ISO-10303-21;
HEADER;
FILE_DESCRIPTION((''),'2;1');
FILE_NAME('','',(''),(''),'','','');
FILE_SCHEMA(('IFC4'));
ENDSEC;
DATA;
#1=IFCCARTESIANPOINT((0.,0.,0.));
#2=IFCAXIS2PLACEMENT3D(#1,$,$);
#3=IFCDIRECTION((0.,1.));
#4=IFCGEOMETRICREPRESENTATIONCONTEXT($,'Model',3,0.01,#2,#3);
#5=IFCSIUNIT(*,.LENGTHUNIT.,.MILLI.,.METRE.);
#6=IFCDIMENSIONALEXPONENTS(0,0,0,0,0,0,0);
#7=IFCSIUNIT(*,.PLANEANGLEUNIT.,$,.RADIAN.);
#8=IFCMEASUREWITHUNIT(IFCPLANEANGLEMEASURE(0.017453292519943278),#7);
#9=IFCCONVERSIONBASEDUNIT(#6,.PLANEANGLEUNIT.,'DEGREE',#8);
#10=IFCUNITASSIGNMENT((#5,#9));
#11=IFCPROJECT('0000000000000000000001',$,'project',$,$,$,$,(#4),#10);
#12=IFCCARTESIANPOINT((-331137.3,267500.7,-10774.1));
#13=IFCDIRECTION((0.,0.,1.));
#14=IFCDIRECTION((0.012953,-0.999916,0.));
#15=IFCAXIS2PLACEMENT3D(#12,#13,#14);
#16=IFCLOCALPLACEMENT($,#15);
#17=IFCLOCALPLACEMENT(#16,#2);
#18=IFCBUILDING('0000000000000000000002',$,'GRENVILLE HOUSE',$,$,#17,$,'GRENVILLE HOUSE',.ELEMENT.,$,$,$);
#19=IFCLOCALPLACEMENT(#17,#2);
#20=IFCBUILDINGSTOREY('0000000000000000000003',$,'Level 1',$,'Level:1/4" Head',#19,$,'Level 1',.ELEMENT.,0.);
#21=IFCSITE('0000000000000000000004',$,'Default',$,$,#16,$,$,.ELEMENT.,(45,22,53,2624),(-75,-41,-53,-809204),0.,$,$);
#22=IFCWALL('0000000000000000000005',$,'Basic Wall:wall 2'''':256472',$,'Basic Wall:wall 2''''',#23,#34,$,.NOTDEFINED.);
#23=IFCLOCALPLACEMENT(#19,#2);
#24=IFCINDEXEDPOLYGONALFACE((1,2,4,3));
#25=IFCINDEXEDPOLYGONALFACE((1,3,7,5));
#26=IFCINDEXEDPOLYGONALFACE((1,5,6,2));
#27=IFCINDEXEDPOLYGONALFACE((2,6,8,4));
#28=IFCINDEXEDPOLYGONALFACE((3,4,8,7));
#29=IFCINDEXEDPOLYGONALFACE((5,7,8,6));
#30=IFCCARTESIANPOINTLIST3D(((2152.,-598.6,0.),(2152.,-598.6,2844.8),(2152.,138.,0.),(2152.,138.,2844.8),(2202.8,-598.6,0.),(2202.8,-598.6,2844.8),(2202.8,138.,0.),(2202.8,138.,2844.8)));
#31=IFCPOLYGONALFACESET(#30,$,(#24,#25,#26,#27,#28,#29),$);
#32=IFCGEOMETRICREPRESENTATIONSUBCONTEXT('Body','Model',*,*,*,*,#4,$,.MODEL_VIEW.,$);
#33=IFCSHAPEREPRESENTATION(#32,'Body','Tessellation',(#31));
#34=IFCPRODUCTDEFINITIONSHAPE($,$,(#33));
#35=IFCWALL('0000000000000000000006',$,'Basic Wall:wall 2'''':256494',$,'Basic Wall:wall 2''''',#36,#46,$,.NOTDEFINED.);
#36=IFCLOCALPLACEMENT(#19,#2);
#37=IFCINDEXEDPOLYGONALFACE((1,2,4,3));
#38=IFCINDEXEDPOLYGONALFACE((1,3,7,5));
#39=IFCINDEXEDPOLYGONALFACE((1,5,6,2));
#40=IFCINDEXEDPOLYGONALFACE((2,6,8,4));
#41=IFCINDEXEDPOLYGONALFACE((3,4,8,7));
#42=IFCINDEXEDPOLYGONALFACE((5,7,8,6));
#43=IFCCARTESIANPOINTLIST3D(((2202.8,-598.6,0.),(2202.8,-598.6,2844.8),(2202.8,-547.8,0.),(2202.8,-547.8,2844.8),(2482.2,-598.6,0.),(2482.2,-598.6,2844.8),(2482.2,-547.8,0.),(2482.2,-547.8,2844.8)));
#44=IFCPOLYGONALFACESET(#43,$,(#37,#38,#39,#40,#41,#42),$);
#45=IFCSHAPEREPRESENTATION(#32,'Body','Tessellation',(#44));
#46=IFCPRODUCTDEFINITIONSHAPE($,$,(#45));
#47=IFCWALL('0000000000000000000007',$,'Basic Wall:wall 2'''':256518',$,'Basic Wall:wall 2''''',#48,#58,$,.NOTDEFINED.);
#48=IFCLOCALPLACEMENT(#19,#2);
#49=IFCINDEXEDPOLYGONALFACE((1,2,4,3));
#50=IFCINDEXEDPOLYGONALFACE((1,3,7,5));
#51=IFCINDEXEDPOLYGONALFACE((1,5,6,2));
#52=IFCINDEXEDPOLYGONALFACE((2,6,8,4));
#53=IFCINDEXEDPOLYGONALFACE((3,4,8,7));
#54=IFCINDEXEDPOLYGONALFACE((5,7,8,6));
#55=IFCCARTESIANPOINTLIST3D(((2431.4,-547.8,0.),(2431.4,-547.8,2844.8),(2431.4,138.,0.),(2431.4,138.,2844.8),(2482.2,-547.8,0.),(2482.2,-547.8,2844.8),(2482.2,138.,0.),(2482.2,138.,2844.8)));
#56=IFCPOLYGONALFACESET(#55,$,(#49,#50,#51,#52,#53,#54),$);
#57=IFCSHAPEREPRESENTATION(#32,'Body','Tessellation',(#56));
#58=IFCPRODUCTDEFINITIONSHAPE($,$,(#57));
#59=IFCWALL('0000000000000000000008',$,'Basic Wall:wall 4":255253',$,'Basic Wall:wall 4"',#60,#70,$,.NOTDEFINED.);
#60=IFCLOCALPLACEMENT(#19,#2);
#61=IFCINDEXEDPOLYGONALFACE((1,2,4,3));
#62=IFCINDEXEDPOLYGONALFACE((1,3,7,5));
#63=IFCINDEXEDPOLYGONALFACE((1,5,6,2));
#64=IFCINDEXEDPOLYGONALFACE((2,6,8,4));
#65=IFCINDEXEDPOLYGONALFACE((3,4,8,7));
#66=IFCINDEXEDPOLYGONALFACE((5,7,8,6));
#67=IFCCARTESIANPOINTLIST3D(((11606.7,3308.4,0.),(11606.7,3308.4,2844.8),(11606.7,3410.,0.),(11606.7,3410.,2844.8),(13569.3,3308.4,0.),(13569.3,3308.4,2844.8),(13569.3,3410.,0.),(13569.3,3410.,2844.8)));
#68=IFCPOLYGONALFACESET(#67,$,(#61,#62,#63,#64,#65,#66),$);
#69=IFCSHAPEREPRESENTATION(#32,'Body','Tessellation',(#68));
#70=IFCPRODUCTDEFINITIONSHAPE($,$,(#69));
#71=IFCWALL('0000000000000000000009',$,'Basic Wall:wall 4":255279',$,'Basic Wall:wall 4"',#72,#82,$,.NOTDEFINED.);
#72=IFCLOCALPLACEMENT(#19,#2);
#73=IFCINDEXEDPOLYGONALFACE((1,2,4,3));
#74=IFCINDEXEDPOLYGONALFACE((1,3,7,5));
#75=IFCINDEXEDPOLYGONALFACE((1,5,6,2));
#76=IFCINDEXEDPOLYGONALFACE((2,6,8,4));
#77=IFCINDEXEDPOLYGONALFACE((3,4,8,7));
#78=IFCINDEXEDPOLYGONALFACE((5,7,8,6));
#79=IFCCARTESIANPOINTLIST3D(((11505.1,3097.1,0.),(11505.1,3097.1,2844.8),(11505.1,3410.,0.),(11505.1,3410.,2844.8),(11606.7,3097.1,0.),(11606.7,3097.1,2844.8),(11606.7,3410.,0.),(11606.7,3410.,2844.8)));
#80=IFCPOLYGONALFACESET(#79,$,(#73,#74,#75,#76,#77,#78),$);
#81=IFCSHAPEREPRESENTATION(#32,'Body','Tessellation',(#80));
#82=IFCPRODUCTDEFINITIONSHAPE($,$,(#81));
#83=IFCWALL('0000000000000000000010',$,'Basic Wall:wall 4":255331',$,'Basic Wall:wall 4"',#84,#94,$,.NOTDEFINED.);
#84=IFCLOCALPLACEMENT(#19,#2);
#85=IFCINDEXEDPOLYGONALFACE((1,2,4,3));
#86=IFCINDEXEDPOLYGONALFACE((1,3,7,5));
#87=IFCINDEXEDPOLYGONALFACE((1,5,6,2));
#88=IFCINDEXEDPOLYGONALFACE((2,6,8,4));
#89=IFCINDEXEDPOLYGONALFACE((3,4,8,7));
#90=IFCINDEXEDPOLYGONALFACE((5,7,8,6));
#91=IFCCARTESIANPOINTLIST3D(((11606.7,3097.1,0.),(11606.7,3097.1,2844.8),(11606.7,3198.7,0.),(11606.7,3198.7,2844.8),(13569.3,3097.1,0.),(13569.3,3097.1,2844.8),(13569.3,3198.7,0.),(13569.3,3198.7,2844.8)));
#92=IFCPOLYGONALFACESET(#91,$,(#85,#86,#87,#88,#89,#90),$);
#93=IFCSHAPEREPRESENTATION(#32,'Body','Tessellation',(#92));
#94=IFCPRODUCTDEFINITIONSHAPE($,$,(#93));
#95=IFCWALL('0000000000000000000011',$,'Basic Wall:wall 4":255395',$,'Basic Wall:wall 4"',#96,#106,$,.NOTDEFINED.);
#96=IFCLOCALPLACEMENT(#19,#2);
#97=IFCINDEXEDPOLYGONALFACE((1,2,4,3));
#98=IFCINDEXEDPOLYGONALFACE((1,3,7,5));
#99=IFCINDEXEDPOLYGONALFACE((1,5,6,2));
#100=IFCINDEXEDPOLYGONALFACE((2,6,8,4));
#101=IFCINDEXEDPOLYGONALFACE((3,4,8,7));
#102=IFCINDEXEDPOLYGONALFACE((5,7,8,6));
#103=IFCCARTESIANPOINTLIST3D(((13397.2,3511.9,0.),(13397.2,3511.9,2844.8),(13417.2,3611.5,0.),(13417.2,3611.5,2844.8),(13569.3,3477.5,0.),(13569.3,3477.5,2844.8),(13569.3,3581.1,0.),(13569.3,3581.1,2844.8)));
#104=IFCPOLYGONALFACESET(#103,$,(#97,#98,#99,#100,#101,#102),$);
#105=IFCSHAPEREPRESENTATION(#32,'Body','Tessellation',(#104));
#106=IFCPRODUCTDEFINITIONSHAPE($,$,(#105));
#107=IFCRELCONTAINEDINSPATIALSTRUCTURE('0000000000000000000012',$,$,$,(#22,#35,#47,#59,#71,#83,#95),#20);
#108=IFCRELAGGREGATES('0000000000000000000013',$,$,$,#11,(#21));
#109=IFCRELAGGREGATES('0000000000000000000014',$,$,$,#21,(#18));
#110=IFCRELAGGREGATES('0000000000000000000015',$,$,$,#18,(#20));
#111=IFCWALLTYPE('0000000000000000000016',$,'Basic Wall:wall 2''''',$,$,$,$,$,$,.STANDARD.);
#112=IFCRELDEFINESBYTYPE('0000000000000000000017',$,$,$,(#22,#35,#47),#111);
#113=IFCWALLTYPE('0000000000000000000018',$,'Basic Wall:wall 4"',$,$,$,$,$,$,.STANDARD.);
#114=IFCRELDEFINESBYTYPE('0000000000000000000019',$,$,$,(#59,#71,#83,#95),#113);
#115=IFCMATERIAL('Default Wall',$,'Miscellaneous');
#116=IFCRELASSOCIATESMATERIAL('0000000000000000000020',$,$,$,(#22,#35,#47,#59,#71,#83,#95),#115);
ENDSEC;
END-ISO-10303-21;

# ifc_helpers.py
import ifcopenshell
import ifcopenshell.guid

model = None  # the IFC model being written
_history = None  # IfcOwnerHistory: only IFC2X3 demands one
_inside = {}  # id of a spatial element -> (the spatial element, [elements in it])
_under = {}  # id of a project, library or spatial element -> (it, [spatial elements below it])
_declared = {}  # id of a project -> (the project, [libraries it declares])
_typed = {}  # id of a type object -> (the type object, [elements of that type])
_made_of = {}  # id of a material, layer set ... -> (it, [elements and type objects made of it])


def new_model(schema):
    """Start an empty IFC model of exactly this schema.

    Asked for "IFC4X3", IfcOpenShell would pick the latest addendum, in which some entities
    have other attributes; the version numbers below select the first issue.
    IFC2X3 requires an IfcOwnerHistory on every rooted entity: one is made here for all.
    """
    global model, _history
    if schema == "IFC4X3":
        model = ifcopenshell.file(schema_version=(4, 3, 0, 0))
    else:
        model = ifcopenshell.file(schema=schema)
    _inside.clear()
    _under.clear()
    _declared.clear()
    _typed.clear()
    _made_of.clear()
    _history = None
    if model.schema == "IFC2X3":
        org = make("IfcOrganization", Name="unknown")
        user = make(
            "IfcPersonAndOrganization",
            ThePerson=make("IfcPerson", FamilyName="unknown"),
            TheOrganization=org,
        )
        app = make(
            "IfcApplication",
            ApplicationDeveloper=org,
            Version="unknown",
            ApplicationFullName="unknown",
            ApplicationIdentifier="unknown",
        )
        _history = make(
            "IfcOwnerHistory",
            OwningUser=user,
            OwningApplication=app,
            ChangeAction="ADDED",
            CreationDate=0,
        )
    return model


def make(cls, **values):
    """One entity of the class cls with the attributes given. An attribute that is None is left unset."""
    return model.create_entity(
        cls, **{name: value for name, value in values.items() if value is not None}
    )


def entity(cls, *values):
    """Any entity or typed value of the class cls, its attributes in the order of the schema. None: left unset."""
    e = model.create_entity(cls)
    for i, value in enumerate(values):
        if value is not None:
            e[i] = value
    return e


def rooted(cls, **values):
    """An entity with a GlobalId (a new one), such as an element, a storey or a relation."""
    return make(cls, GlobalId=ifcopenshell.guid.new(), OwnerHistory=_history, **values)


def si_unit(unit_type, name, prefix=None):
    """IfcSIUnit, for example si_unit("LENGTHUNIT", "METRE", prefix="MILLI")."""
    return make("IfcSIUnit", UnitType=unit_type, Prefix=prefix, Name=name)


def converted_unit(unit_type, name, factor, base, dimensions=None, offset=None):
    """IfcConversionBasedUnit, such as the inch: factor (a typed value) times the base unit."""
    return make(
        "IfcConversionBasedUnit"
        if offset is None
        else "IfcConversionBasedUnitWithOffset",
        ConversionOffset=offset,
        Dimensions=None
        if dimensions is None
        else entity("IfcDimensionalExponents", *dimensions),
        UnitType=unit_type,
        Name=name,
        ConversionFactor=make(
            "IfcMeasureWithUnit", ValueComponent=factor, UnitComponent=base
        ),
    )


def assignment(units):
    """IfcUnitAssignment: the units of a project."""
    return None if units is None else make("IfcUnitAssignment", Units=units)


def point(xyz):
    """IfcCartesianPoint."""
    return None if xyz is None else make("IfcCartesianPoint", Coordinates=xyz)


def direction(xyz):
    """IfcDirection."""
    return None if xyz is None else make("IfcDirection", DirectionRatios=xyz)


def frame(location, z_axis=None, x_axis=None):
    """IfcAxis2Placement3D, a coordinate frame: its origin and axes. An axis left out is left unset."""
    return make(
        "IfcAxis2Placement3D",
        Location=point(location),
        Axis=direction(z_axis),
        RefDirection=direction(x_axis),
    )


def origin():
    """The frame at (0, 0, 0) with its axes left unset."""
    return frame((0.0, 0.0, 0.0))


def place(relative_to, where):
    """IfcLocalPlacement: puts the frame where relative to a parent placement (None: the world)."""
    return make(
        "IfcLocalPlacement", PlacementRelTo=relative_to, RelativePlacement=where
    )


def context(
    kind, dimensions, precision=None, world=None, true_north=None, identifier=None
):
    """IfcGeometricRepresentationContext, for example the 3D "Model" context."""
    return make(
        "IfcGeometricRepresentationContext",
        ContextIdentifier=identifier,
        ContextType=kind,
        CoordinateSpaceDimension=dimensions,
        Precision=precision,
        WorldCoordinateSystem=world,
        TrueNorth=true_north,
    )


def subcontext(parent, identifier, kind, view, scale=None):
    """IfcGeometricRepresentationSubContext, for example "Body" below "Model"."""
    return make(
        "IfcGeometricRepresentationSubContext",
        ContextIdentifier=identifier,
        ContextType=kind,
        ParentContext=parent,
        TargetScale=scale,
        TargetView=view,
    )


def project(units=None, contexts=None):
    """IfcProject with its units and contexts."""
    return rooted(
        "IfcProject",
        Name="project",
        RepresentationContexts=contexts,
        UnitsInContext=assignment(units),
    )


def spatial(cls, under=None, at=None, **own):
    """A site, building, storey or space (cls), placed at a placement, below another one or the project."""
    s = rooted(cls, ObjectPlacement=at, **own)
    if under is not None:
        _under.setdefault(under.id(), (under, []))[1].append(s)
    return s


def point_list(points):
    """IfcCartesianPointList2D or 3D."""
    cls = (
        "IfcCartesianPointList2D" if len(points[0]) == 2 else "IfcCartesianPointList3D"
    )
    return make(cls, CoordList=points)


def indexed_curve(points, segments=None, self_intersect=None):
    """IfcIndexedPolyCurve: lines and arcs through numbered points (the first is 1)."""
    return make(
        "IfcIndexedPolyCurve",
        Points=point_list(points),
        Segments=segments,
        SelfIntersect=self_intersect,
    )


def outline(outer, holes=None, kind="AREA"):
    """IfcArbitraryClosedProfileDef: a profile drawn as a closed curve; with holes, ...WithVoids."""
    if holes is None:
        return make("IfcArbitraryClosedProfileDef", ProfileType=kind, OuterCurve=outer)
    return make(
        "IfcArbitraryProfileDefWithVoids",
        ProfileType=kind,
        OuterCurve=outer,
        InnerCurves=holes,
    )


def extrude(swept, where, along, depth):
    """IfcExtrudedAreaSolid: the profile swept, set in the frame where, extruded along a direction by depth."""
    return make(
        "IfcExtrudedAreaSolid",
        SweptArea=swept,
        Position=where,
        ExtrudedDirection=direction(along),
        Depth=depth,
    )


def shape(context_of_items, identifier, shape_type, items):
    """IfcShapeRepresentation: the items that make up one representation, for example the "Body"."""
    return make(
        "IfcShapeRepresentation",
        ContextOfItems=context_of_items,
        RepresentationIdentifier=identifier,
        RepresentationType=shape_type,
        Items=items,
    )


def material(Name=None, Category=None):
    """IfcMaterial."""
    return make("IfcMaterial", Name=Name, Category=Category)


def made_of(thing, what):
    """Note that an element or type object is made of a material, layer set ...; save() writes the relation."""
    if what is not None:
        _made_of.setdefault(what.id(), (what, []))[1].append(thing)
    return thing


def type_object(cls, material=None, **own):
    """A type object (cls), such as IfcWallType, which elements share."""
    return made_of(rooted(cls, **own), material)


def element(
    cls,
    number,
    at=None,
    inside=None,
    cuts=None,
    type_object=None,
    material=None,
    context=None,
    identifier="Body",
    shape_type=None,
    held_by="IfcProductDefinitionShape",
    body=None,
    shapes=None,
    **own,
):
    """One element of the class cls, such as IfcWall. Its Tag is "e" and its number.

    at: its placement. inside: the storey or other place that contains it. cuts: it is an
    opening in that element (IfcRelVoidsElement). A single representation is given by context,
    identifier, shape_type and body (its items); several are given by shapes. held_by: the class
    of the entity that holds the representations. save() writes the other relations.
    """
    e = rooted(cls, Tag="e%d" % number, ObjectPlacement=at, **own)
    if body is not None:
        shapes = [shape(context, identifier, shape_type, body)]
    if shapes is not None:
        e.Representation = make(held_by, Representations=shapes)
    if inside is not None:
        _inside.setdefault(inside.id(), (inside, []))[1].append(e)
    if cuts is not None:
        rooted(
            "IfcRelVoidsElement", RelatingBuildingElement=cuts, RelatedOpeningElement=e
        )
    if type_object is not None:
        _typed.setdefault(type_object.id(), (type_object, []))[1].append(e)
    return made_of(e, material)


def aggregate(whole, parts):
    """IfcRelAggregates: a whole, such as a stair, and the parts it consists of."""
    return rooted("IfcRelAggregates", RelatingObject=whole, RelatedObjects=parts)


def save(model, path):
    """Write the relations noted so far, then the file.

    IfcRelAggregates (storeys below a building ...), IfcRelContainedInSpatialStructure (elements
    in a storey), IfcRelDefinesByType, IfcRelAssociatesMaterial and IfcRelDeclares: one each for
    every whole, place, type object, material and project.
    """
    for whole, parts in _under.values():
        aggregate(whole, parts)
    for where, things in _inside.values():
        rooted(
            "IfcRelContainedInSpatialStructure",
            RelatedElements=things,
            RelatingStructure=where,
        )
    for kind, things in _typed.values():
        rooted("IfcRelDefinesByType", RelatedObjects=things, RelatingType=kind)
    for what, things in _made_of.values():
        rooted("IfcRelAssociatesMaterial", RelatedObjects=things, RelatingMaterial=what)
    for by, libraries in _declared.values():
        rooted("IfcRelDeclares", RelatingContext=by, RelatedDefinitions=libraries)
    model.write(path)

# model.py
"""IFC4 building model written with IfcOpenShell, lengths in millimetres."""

from ifc_helpers import new_model, entity, si_unit, converted_unit, direction, frame, origin, place, context, subcontext, project, spatial, indexed_curve, outline, extrude, material, type_object, element, save


model = new_model("IFC4")

# Units and contexts
model_context = context("Model", 3, precision=0.01, world=origin(), true_north=direction((0.0, 1.0)))
body_context = subcontext(model_context, "Body", "Model", "MODEL_VIEW")
ifc_project = project(units=[si_unit("LENGTHUNIT", "METRE", prefix="MILLI"), converted_unit("PLANEANGLEUNIT", "DEGREE", entity("IfcPlaneAngleMeasure", 0.017453292519943278), si_unit("PLANEANGLEUNIT", "RADIAN"), dimensions=[0, 0, 0, 0, 0, 0, 0])], contexts=[model_context])

# Site, building, storey
site_placement = place(None, frame((-331137.3, 267500.7, -10774.1), z_axis=(0.0, 0.0, 1.0), x_axis=(0.012953, -0.999916, 0.0)))
site = spatial("IfcSite", under=ifc_project, at=site_placement, Name="Default", CompositionType="ELEMENT", RefLatitude=(45, 22, 53, 2624), RefLongitude=(-75, -41, -53, -809204), RefElevation=0.0)
building_placement = place(site_placement, origin())
building = spatial("IfcBuilding", under=site, at=building_placement, Name="GRENVILLE HOUSE", LongName="GRENVILLE HOUSE", CompositionType="ELEMENT")
storey_placement = place(building_placement, origin())
storey = spatial("IfcBuildingStorey", under=building, at=storey_placement, Name="Level 1", ObjectType="Level:1/4\" Head", LongName="Level 1", CompositionType="ELEMENT", Elevation=0.0)

# Walls
ifc_material_1 = material(Name="Default Wall", Category="Miscellaneous")
wall_type_1 = type_object("IfcWallType", Name="Basic Wall:wall 2''", PredefinedType="STANDARD")
wall_1_placement = place(storey_placement, frame((2177.4, 138.0, 0.0), z_axis=(0.0, 0.0, 1.0), x_axis=(0.0, -1.0, 0.0)))
element("IfcWall", 1, at=wall_1_placement, inside=storey, type_object=wall_type_1, material=ifc_material_1, Name="Basic Wall:wall 2'':256472", ObjectType="Basic Wall:wall 2''", PredefinedType="NOTDEFINED", context=body_context, shape_type="SweptSolid", body=[
    extrude(outline(indexed_curve([(736.6, 25.4), (0.0, 25.4), (0.0, -25.4), (736.6, -25.4), (736.6, 25.4)], self_intersect=False)), origin(), (0.0, 0.0, 1.0), 2844.8),
])
wall_2_placement = place(storey_placement, frame((2202.8, -573.2, 0.0)))
element("IfcWall", 2, at=wall_2_placement, inside=storey, type_object=wall_type_1, material=ifc_material_1, Name="Basic Wall:wall 2'':256494", ObjectType="Basic Wall:wall 2''", PredefinedType="NOTDEFINED", context=body_context, shape_type="SweptSolid", body=[
    extrude(outline(indexed_curve([(279.4, 25.4), (0.0, 25.4), (0.0, -25.4), (279.4, -25.4), (279.4, 25.4)], self_intersect=False)), origin(), (0.0, 0.0, 1.0), 2844.8),
])
wall_3_placement = place(storey_placement, frame((2456.8, -547.8, 0.0), z_axis=(0.0, 0.0, 1.0), x_axis=(0.0, 1.0, 0.0)))
element("IfcWall", 3, at=wall_3_placement, inside=storey, type_object=wall_type_1, material=ifc_material_1, Name="Basic Wall:wall 2'':256518", ObjectType="Basic Wall:wall 2''", PredefinedType="NOTDEFINED", context=body_context, shape_type="SweptSolid", body=[
    extrude(outline(indexed_curve([(685.8, 25.4), (0.0, 25.4), (0.0, -25.4), (685.8, -25.4), (685.8, 25.4)], self_intersect=False)), origin(), (0.0, 0.0, 1.0), 2844.8),
])
wall_type_2 = type_object("IfcWallType", Name="Basic Wall:wall 4\"", PredefinedType="STANDARD")
wall_4_placement = place(storey_placement, frame((13569.3, 3359.2, 0.0), z_axis=(0.0, 0.0, 1.0), x_axis=(-1.0, 0.0, 0.0)))
element("IfcWall", 4, at=wall_4_placement, inside=storey, type_object=wall_type_2, material=ifc_material_1, Name="Basic Wall:wall 4\":255253", ObjectType="Basic Wall:wall 4\"", PredefinedType="NOTDEFINED", context=body_context, shape_type="SweptSolid", body=[
    extrude(outline(indexed_curve([(1962.7, 50.8), (0.0, 50.8), (0.0, -50.8), (1962.7, -50.8), (1962.7, 50.8)], self_intersect=False)), origin(), (0.0, 0.0, 1.0), 2844.8),
])
wall_5_placement = place(storey_placement, frame((11555.9, 3410.0, 0.0), z_axis=(0.0, 0.0, 1.0), x_axis=(0.0, -1.0, 0.0)))
element("IfcWall", 5, at=wall_5_placement, inside=storey, type_object=wall_type_2, material=ifc_material_1, Name="Basic Wall:wall 4\":255279", ObjectType="Basic Wall:wall 4\"", PredefinedType="NOTDEFINED", context=body_context, shape_type="SweptSolid", body=[
    extrude(outline(indexed_curve([(312.9, 50.8), (0.0, 50.8), (0.0, -50.8), (312.9, -50.8), (312.9, 50.8)], self_intersect=False)), origin(), (0.0, 0.0, 1.0), 2844.8),
])
wall_6_placement = place(storey_placement, frame((11606.7, 3147.9, 0.0)))
element("IfcWall", 6, at=wall_6_placement, inside=storey, type_object=wall_type_2, material=ifc_material_1, Name="Basic Wall:wall 4\":255331", ObjectType="Basic Wall:wall 4\"", PredefinedType="NOTDEFINED", context=body_context, shape_type="SweptSolid", body=[
    extrude(outline(indexed_curve([(1962.7, 50.8), (0.0, 50.8), (0.0, -50.8), (1962.7, -50.8), (1962.7, 50.8)], self_intersect=False)), origin(), (0.0, 0.0, 1.0), 2844.8),
])
wall_7_placement = place(storey_placement, frame((13579.3, 3527.3, 0.0), z_axis=(0.0, 0.0, 1.0), x_axis=(-0.980581, 0.196116, 0.0)))
element("IfcWall", 7, at=wall_7_placement, inside=storey, type_object=wall_type_2, material=ifc_material_1, Name="Basic Wall:wall 4\":255395", ObjectType="Basic Wall:wall 4\"", PredefinedType="NOTDEFINED", context=body_context, shape_type="SweptSolid", body=[
    extrude(outline(indexed_curve([(175.5, -50.8), (175.5, 50.8), (0.0, 50.8), (20.3, -50.8), (175.5, -50.8)], self_intersect=False)), origin(), (0.0, 0.0, 1.0), 2844.8),
])

save(model, "model.ifc")
